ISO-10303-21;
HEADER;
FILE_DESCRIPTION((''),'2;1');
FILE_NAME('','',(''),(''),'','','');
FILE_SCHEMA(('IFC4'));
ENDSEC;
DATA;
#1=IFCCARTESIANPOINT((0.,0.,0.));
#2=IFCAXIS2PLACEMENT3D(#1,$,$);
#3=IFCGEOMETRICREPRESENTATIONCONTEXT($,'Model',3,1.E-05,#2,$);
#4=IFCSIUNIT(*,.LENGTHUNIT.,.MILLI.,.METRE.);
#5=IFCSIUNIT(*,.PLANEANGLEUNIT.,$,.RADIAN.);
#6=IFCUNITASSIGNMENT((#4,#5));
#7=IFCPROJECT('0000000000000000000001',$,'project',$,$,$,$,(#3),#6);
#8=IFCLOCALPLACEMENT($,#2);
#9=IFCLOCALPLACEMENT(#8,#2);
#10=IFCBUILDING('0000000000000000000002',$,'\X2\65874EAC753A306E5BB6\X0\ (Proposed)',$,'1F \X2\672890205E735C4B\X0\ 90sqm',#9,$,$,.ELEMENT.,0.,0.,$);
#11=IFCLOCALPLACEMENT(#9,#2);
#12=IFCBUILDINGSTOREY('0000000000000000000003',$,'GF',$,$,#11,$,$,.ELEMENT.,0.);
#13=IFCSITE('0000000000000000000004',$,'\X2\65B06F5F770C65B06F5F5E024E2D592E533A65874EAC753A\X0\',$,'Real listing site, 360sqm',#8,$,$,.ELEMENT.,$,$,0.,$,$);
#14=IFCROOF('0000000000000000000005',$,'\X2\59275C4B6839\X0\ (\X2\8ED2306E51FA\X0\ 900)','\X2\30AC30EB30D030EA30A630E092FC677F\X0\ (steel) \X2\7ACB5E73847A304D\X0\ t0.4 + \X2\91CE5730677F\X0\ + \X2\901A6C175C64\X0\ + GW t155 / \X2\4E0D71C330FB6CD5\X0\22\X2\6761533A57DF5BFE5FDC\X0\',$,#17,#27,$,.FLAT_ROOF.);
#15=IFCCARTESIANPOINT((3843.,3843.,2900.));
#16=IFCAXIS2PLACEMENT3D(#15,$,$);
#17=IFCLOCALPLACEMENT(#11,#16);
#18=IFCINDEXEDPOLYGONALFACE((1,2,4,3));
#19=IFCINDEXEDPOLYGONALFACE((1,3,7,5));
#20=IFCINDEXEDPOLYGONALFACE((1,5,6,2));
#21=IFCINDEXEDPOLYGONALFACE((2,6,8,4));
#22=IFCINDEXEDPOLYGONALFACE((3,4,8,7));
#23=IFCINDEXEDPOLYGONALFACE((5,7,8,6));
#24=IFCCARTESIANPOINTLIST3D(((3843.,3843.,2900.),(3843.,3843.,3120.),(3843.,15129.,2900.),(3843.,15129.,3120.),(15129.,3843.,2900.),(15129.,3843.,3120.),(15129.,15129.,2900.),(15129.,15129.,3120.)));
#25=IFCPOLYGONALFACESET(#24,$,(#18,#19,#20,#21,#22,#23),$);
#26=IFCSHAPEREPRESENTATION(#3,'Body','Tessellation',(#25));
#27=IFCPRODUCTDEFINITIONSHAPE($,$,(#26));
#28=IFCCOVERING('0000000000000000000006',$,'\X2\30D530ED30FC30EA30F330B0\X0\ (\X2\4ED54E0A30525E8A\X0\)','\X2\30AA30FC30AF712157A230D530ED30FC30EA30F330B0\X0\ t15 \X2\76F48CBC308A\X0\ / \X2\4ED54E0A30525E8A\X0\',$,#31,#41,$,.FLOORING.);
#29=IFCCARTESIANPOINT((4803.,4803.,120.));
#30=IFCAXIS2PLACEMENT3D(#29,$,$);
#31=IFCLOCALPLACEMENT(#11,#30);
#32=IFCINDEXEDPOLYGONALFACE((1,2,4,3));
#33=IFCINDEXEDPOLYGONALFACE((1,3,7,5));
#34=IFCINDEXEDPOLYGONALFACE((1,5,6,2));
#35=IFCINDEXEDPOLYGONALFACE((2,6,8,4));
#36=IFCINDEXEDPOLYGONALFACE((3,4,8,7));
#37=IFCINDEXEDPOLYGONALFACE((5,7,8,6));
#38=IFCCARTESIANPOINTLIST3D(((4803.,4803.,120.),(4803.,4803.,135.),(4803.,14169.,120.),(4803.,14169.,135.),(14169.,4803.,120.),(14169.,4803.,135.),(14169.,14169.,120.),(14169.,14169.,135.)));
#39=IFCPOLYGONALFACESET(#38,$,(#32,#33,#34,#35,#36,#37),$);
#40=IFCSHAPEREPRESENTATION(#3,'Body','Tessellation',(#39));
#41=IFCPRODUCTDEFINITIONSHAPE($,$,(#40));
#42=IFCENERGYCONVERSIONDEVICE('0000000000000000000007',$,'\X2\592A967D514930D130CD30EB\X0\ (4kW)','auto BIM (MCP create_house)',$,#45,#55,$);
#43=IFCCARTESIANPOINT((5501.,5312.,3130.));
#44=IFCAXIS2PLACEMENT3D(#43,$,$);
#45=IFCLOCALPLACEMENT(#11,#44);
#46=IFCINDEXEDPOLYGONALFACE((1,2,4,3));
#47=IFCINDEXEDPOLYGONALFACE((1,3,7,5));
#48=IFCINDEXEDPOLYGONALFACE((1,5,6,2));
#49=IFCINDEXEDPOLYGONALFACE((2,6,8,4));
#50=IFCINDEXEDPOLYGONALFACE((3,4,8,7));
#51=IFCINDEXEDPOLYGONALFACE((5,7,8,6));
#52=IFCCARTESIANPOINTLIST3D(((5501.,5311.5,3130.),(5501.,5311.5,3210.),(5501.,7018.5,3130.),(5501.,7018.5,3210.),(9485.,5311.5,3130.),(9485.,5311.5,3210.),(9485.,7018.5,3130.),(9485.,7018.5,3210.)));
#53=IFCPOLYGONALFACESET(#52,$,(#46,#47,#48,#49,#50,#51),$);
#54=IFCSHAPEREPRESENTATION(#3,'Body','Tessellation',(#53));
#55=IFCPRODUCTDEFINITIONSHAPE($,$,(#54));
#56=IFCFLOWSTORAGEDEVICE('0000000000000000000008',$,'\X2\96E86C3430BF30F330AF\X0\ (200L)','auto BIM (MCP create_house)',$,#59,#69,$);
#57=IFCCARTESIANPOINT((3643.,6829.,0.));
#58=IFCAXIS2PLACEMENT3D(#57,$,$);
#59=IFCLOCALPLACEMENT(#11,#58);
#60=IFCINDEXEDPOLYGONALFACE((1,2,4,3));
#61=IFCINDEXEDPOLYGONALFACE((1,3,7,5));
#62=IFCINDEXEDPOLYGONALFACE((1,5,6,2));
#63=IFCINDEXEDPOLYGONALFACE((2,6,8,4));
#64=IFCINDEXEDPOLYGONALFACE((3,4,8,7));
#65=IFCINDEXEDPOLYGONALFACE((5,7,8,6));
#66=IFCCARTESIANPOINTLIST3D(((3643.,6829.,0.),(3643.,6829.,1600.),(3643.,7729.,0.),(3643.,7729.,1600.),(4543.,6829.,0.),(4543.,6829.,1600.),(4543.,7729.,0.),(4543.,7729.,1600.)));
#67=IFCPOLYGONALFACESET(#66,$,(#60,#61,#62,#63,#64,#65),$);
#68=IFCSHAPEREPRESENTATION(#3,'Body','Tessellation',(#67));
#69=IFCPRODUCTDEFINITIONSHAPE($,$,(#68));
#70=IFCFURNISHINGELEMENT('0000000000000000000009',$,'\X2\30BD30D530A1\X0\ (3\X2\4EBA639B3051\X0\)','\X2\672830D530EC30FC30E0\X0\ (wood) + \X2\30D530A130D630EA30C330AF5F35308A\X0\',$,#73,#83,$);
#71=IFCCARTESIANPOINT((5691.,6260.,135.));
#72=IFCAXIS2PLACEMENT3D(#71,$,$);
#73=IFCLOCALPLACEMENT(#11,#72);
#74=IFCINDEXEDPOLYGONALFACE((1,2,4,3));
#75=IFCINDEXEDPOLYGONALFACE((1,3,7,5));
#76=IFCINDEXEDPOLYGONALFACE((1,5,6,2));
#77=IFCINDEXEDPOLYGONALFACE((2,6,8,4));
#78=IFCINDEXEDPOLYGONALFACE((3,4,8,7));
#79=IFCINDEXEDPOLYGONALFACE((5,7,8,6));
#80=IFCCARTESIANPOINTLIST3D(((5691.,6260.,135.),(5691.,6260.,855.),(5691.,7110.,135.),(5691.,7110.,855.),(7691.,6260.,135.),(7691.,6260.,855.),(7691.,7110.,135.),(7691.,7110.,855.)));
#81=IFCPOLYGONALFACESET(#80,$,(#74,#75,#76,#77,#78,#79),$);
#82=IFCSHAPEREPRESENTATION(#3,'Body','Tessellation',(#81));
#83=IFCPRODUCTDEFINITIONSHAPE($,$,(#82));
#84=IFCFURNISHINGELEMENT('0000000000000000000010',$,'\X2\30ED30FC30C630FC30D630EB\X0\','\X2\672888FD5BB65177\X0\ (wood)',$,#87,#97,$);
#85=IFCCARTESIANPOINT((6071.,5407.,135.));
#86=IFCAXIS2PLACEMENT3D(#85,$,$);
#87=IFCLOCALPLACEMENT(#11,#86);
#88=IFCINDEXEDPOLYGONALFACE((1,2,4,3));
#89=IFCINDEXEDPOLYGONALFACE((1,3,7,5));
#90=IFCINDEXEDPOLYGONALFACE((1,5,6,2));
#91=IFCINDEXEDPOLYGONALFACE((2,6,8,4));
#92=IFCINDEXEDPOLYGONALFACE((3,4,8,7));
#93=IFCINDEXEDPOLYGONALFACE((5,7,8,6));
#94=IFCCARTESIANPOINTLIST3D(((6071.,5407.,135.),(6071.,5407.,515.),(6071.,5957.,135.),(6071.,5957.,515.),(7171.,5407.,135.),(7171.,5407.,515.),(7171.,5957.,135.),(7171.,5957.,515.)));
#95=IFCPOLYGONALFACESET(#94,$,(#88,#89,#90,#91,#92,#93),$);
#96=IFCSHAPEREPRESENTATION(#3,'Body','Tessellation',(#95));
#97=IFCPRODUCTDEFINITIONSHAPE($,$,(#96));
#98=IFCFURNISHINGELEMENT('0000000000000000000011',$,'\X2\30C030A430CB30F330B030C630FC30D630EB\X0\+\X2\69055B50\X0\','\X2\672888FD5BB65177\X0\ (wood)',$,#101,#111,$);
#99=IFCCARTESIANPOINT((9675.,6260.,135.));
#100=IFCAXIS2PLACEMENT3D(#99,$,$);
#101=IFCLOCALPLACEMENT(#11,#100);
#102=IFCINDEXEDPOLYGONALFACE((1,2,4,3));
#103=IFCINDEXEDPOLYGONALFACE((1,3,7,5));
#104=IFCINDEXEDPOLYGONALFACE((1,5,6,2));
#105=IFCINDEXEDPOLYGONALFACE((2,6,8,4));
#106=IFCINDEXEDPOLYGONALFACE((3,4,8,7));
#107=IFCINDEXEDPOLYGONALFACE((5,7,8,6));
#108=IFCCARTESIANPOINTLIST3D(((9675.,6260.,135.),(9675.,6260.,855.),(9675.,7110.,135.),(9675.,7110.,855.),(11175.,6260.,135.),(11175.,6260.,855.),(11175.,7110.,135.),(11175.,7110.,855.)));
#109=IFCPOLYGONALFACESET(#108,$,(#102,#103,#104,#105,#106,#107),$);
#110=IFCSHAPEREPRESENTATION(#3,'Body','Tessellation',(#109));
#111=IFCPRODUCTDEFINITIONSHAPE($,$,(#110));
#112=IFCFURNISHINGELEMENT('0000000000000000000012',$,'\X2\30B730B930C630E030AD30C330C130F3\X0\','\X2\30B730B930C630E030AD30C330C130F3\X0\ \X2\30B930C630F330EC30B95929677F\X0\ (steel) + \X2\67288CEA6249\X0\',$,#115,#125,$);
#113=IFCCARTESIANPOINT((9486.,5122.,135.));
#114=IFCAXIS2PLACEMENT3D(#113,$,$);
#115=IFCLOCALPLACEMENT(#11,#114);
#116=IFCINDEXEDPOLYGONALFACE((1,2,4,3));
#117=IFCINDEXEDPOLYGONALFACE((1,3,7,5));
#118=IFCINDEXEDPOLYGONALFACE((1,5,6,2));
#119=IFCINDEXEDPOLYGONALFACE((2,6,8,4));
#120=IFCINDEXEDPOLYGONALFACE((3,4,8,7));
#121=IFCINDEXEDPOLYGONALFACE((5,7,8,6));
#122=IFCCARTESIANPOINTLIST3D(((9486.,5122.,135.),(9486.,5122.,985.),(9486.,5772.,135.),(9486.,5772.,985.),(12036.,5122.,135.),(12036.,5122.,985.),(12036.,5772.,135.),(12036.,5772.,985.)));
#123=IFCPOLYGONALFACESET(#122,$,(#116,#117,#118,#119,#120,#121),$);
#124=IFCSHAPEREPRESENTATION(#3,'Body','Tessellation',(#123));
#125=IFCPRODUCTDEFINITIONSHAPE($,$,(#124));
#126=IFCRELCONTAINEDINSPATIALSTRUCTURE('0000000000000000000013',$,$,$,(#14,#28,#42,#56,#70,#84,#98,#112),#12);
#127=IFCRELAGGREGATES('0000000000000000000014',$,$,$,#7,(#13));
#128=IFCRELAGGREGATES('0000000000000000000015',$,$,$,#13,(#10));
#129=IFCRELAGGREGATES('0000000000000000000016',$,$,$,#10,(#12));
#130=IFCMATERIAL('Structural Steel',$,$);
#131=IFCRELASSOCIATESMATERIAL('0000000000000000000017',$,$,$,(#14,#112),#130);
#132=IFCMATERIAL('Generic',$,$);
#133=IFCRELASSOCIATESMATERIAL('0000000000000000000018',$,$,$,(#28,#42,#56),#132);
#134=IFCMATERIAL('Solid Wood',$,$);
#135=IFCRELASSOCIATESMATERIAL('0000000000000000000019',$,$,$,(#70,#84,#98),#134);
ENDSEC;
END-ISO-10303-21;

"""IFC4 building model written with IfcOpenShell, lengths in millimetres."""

from ifc_helpers import new_model, si_unit, frame, frame_2d, origin, place, context, project, spatial, rectangle, extrude, material, element, save


model = new_model("IFC4")

# Units and contexts
model_context = context("Model", 3, precision=1e-05, world=origin())
ifc_project = project(units=[si_unit("LENGTHUNIT", "METRE", prefix="MILLI"), si_unit("PLANEANGLEUNIT", "RADIAN")], contexts=[model_context])

# Site, building, storey
site_placement = place(None, origin())
site = spatial("IfcSite", under=ifc_project, at=site_placement, Name="新潟県新潟市中央区文京町", ObjectType="Real listing site, 360sqm", CompositionType="ELEMENT", RefElevation=0.0)
building_placement = place(site_placement, origin())
building = spatial("IfcBuilding", under=site, at=building_placement, Name="文京町の家 (Proposed)", ObjectType="1F 木造平屋 90sqm", CompositionType="ELEMENT", ElevationOfRefHeight=0.0, ElevationOfTerrain=0.0)
storey_placement = place(building_placement, origin())
storey = spatial("IfcBuildingStorey", under=building, at=storey_placement, Name="GF", CompositionType="ELEMENT", Elevation=0.0)

# Shared definitions
ifc_material_1 = material(Name="Solid Wood")

# Roof
ifc_material_2 = material(Name="Structural Steel")
roof_placement = place(storey_placement, frame((3843.0, 3843.0, 2900.0)))
element("IfcRoof", 1, at=roof_placement, inside=storey, material=ifc_material_2, Name="大屋根 (軒の出 900)", Description="ガルバリウム鋼板 (steel) 立平葺き t0.4 + 野地板 + 通気層 + GW t155 / 不燃・法22条区域対応", PredefinedType="FLAT_ROOF", context=model_context, shape_type="SweptSolid", body=[
    extrude(rectangle(XDim=11286.0, YDim=11286.0, at=frame_2d((5643.0, 5643.0))), frame((3843.0, 3843.0, 2900.0)), (0.0, 0.0, 1.0), 220.0),
])

# Covering
ifc_material_3 = material(Name="Generic")
covering_placement = place(storey_placement, frame((4803.0, 4803.0, 120.0)))
element("IfcCovering", 2, at=covering_placement, inside=storey, material=ifc_material_3, Name="フローリング (仕上げ床)", Description="オーク無垢フローリング t15 直貼り / 仕上げ床", PredefinedType="FLOORING", context=model_context, shape_type="SweptSolid", body=[
    extrude(rectangle(XDim=9366.0, YDim=9366.0, at=frame_2d((4683.0, 4683.0))), frame((4803.0, 4803.0, 120.0)), (0.0, 0.0, 1.0), 15.0),
])

# Energy conversion device
energy_conversion_device_placement = place(storey_placement, frame((5501.0, 5312.0, 3130.0)))
element("IfcEnergyConversionDevice", 3, at=energy_conversion_device_placement, inside=storey, material=ifc_material_3, Name="太陽光パネル (4kW)", Description="auto BIM (MCP create_house)", context=model_context, shape_type="SweptSolid", body=[
    extrude(rectangle(XDim=3984.0, YDim=1707.0, at=frame_2d((1992.0, 853.0))), frame((5501.0, 5312.0, 3130.0)), (0.0, 0.0, 1.0), 80.0),
])

# Flow storage device
flow_storage_device_placement = place(storey_placement, frame((3643.0, 6829.0, 0.0)))
element("IfcFlowStorageDevice", 4, at=flow_storage_device_placement, inside=storey, material=ifc_material_3, Name="雨水タンク (200L)", Description="auto BIM (MCP create_house)", context=model_context, shape_type="SweptSolid", body=[
    extrude(rectangle(XDim=900.0, YDim=900.0, at=frame_2d((450.0, 450.0))), frame((3643.0, 6829.0, 0.0)), (0.0, 0.0, 1.0), 1600.0),
])

# Furnishing elements
furnishing_1_placement = place(storey_placement, frame((5691.0, 6260.0, 135.0)))
element("IfcFurnishingElement", 5, at=furnishing_1_placement, inside=storey, material=ifc_material_1, Name="ソファ (3人掛け)", Description="木フレーム (wood) + ファブリック張り", context=model_context, shape_type="SweptSolid", body=[
    extrude(rectangle(XDim=2000.0, YDim=850.0, at=frame_2d((1000.0, 425.0))), frame((5691.0, 6260.0, 135.0)), (0.0, 0.0, 1.0), 720.0),
])
furnishing_2_placement = place(storey_placement, frame((6071.0, 5407.0, 135.0)))
element("IfcFurnishingElement", 6, at=furnishing_2_placement, inside=storey, material=ifc_material_1, Name="ローテーブル", Description="木製家具 (wood)", context=model_context, shape_type="SweptSolid", body=[
    extrude(rectangle(XDim=1100.0, YDim=550.0, at=frame_2d((550.0, 275.0))), frame((6071.0, 5407.0, 135.0)), (0.0, 0.0, 1.0), 380.0),
])
furnishing_3_placement = place(storey_placement, frame((9675.0, 6260.0, 135.0)))
element("IfcFurnishingElement", 7, at=furnishing_3_placement, inside=storey, material=ifc_material_1, Name="ダイニングテーブル+椅子", Description="木製家具 (wood)", context=model_context, shape_type="SweptSolid", body=[
    extrude(rectangle(XDim=1500.0, YDim=850.0, at=frame_2d((750.0, 425.0))), frame((9675.0, 6260.0, 135.0)), (0.0, 0.0, 1.0), 720.0),
])
furnishing_4_placement = place(storey_placement, frame((9486.0, 5122.0, 135.0)))
element("IfcFurnishingElement", 8, at=furnishing_4_placement, inside=storey, material=ifc_material_2, Name="システムキッチン", Description="システムキッチン ステンレス天板 (steel) + 木質扉", context=model_context, shape_type="SweptSolid", body=[
    extrude(rectangle(XDim=2550.0, YDim=650.0, at=frame_2d((1275.0, 325.0))), frame((9486.0, 5122.0, 135.0)), (0.0, 0.0, 1.0), 850.0),
])

save(model, "model.ifc")
